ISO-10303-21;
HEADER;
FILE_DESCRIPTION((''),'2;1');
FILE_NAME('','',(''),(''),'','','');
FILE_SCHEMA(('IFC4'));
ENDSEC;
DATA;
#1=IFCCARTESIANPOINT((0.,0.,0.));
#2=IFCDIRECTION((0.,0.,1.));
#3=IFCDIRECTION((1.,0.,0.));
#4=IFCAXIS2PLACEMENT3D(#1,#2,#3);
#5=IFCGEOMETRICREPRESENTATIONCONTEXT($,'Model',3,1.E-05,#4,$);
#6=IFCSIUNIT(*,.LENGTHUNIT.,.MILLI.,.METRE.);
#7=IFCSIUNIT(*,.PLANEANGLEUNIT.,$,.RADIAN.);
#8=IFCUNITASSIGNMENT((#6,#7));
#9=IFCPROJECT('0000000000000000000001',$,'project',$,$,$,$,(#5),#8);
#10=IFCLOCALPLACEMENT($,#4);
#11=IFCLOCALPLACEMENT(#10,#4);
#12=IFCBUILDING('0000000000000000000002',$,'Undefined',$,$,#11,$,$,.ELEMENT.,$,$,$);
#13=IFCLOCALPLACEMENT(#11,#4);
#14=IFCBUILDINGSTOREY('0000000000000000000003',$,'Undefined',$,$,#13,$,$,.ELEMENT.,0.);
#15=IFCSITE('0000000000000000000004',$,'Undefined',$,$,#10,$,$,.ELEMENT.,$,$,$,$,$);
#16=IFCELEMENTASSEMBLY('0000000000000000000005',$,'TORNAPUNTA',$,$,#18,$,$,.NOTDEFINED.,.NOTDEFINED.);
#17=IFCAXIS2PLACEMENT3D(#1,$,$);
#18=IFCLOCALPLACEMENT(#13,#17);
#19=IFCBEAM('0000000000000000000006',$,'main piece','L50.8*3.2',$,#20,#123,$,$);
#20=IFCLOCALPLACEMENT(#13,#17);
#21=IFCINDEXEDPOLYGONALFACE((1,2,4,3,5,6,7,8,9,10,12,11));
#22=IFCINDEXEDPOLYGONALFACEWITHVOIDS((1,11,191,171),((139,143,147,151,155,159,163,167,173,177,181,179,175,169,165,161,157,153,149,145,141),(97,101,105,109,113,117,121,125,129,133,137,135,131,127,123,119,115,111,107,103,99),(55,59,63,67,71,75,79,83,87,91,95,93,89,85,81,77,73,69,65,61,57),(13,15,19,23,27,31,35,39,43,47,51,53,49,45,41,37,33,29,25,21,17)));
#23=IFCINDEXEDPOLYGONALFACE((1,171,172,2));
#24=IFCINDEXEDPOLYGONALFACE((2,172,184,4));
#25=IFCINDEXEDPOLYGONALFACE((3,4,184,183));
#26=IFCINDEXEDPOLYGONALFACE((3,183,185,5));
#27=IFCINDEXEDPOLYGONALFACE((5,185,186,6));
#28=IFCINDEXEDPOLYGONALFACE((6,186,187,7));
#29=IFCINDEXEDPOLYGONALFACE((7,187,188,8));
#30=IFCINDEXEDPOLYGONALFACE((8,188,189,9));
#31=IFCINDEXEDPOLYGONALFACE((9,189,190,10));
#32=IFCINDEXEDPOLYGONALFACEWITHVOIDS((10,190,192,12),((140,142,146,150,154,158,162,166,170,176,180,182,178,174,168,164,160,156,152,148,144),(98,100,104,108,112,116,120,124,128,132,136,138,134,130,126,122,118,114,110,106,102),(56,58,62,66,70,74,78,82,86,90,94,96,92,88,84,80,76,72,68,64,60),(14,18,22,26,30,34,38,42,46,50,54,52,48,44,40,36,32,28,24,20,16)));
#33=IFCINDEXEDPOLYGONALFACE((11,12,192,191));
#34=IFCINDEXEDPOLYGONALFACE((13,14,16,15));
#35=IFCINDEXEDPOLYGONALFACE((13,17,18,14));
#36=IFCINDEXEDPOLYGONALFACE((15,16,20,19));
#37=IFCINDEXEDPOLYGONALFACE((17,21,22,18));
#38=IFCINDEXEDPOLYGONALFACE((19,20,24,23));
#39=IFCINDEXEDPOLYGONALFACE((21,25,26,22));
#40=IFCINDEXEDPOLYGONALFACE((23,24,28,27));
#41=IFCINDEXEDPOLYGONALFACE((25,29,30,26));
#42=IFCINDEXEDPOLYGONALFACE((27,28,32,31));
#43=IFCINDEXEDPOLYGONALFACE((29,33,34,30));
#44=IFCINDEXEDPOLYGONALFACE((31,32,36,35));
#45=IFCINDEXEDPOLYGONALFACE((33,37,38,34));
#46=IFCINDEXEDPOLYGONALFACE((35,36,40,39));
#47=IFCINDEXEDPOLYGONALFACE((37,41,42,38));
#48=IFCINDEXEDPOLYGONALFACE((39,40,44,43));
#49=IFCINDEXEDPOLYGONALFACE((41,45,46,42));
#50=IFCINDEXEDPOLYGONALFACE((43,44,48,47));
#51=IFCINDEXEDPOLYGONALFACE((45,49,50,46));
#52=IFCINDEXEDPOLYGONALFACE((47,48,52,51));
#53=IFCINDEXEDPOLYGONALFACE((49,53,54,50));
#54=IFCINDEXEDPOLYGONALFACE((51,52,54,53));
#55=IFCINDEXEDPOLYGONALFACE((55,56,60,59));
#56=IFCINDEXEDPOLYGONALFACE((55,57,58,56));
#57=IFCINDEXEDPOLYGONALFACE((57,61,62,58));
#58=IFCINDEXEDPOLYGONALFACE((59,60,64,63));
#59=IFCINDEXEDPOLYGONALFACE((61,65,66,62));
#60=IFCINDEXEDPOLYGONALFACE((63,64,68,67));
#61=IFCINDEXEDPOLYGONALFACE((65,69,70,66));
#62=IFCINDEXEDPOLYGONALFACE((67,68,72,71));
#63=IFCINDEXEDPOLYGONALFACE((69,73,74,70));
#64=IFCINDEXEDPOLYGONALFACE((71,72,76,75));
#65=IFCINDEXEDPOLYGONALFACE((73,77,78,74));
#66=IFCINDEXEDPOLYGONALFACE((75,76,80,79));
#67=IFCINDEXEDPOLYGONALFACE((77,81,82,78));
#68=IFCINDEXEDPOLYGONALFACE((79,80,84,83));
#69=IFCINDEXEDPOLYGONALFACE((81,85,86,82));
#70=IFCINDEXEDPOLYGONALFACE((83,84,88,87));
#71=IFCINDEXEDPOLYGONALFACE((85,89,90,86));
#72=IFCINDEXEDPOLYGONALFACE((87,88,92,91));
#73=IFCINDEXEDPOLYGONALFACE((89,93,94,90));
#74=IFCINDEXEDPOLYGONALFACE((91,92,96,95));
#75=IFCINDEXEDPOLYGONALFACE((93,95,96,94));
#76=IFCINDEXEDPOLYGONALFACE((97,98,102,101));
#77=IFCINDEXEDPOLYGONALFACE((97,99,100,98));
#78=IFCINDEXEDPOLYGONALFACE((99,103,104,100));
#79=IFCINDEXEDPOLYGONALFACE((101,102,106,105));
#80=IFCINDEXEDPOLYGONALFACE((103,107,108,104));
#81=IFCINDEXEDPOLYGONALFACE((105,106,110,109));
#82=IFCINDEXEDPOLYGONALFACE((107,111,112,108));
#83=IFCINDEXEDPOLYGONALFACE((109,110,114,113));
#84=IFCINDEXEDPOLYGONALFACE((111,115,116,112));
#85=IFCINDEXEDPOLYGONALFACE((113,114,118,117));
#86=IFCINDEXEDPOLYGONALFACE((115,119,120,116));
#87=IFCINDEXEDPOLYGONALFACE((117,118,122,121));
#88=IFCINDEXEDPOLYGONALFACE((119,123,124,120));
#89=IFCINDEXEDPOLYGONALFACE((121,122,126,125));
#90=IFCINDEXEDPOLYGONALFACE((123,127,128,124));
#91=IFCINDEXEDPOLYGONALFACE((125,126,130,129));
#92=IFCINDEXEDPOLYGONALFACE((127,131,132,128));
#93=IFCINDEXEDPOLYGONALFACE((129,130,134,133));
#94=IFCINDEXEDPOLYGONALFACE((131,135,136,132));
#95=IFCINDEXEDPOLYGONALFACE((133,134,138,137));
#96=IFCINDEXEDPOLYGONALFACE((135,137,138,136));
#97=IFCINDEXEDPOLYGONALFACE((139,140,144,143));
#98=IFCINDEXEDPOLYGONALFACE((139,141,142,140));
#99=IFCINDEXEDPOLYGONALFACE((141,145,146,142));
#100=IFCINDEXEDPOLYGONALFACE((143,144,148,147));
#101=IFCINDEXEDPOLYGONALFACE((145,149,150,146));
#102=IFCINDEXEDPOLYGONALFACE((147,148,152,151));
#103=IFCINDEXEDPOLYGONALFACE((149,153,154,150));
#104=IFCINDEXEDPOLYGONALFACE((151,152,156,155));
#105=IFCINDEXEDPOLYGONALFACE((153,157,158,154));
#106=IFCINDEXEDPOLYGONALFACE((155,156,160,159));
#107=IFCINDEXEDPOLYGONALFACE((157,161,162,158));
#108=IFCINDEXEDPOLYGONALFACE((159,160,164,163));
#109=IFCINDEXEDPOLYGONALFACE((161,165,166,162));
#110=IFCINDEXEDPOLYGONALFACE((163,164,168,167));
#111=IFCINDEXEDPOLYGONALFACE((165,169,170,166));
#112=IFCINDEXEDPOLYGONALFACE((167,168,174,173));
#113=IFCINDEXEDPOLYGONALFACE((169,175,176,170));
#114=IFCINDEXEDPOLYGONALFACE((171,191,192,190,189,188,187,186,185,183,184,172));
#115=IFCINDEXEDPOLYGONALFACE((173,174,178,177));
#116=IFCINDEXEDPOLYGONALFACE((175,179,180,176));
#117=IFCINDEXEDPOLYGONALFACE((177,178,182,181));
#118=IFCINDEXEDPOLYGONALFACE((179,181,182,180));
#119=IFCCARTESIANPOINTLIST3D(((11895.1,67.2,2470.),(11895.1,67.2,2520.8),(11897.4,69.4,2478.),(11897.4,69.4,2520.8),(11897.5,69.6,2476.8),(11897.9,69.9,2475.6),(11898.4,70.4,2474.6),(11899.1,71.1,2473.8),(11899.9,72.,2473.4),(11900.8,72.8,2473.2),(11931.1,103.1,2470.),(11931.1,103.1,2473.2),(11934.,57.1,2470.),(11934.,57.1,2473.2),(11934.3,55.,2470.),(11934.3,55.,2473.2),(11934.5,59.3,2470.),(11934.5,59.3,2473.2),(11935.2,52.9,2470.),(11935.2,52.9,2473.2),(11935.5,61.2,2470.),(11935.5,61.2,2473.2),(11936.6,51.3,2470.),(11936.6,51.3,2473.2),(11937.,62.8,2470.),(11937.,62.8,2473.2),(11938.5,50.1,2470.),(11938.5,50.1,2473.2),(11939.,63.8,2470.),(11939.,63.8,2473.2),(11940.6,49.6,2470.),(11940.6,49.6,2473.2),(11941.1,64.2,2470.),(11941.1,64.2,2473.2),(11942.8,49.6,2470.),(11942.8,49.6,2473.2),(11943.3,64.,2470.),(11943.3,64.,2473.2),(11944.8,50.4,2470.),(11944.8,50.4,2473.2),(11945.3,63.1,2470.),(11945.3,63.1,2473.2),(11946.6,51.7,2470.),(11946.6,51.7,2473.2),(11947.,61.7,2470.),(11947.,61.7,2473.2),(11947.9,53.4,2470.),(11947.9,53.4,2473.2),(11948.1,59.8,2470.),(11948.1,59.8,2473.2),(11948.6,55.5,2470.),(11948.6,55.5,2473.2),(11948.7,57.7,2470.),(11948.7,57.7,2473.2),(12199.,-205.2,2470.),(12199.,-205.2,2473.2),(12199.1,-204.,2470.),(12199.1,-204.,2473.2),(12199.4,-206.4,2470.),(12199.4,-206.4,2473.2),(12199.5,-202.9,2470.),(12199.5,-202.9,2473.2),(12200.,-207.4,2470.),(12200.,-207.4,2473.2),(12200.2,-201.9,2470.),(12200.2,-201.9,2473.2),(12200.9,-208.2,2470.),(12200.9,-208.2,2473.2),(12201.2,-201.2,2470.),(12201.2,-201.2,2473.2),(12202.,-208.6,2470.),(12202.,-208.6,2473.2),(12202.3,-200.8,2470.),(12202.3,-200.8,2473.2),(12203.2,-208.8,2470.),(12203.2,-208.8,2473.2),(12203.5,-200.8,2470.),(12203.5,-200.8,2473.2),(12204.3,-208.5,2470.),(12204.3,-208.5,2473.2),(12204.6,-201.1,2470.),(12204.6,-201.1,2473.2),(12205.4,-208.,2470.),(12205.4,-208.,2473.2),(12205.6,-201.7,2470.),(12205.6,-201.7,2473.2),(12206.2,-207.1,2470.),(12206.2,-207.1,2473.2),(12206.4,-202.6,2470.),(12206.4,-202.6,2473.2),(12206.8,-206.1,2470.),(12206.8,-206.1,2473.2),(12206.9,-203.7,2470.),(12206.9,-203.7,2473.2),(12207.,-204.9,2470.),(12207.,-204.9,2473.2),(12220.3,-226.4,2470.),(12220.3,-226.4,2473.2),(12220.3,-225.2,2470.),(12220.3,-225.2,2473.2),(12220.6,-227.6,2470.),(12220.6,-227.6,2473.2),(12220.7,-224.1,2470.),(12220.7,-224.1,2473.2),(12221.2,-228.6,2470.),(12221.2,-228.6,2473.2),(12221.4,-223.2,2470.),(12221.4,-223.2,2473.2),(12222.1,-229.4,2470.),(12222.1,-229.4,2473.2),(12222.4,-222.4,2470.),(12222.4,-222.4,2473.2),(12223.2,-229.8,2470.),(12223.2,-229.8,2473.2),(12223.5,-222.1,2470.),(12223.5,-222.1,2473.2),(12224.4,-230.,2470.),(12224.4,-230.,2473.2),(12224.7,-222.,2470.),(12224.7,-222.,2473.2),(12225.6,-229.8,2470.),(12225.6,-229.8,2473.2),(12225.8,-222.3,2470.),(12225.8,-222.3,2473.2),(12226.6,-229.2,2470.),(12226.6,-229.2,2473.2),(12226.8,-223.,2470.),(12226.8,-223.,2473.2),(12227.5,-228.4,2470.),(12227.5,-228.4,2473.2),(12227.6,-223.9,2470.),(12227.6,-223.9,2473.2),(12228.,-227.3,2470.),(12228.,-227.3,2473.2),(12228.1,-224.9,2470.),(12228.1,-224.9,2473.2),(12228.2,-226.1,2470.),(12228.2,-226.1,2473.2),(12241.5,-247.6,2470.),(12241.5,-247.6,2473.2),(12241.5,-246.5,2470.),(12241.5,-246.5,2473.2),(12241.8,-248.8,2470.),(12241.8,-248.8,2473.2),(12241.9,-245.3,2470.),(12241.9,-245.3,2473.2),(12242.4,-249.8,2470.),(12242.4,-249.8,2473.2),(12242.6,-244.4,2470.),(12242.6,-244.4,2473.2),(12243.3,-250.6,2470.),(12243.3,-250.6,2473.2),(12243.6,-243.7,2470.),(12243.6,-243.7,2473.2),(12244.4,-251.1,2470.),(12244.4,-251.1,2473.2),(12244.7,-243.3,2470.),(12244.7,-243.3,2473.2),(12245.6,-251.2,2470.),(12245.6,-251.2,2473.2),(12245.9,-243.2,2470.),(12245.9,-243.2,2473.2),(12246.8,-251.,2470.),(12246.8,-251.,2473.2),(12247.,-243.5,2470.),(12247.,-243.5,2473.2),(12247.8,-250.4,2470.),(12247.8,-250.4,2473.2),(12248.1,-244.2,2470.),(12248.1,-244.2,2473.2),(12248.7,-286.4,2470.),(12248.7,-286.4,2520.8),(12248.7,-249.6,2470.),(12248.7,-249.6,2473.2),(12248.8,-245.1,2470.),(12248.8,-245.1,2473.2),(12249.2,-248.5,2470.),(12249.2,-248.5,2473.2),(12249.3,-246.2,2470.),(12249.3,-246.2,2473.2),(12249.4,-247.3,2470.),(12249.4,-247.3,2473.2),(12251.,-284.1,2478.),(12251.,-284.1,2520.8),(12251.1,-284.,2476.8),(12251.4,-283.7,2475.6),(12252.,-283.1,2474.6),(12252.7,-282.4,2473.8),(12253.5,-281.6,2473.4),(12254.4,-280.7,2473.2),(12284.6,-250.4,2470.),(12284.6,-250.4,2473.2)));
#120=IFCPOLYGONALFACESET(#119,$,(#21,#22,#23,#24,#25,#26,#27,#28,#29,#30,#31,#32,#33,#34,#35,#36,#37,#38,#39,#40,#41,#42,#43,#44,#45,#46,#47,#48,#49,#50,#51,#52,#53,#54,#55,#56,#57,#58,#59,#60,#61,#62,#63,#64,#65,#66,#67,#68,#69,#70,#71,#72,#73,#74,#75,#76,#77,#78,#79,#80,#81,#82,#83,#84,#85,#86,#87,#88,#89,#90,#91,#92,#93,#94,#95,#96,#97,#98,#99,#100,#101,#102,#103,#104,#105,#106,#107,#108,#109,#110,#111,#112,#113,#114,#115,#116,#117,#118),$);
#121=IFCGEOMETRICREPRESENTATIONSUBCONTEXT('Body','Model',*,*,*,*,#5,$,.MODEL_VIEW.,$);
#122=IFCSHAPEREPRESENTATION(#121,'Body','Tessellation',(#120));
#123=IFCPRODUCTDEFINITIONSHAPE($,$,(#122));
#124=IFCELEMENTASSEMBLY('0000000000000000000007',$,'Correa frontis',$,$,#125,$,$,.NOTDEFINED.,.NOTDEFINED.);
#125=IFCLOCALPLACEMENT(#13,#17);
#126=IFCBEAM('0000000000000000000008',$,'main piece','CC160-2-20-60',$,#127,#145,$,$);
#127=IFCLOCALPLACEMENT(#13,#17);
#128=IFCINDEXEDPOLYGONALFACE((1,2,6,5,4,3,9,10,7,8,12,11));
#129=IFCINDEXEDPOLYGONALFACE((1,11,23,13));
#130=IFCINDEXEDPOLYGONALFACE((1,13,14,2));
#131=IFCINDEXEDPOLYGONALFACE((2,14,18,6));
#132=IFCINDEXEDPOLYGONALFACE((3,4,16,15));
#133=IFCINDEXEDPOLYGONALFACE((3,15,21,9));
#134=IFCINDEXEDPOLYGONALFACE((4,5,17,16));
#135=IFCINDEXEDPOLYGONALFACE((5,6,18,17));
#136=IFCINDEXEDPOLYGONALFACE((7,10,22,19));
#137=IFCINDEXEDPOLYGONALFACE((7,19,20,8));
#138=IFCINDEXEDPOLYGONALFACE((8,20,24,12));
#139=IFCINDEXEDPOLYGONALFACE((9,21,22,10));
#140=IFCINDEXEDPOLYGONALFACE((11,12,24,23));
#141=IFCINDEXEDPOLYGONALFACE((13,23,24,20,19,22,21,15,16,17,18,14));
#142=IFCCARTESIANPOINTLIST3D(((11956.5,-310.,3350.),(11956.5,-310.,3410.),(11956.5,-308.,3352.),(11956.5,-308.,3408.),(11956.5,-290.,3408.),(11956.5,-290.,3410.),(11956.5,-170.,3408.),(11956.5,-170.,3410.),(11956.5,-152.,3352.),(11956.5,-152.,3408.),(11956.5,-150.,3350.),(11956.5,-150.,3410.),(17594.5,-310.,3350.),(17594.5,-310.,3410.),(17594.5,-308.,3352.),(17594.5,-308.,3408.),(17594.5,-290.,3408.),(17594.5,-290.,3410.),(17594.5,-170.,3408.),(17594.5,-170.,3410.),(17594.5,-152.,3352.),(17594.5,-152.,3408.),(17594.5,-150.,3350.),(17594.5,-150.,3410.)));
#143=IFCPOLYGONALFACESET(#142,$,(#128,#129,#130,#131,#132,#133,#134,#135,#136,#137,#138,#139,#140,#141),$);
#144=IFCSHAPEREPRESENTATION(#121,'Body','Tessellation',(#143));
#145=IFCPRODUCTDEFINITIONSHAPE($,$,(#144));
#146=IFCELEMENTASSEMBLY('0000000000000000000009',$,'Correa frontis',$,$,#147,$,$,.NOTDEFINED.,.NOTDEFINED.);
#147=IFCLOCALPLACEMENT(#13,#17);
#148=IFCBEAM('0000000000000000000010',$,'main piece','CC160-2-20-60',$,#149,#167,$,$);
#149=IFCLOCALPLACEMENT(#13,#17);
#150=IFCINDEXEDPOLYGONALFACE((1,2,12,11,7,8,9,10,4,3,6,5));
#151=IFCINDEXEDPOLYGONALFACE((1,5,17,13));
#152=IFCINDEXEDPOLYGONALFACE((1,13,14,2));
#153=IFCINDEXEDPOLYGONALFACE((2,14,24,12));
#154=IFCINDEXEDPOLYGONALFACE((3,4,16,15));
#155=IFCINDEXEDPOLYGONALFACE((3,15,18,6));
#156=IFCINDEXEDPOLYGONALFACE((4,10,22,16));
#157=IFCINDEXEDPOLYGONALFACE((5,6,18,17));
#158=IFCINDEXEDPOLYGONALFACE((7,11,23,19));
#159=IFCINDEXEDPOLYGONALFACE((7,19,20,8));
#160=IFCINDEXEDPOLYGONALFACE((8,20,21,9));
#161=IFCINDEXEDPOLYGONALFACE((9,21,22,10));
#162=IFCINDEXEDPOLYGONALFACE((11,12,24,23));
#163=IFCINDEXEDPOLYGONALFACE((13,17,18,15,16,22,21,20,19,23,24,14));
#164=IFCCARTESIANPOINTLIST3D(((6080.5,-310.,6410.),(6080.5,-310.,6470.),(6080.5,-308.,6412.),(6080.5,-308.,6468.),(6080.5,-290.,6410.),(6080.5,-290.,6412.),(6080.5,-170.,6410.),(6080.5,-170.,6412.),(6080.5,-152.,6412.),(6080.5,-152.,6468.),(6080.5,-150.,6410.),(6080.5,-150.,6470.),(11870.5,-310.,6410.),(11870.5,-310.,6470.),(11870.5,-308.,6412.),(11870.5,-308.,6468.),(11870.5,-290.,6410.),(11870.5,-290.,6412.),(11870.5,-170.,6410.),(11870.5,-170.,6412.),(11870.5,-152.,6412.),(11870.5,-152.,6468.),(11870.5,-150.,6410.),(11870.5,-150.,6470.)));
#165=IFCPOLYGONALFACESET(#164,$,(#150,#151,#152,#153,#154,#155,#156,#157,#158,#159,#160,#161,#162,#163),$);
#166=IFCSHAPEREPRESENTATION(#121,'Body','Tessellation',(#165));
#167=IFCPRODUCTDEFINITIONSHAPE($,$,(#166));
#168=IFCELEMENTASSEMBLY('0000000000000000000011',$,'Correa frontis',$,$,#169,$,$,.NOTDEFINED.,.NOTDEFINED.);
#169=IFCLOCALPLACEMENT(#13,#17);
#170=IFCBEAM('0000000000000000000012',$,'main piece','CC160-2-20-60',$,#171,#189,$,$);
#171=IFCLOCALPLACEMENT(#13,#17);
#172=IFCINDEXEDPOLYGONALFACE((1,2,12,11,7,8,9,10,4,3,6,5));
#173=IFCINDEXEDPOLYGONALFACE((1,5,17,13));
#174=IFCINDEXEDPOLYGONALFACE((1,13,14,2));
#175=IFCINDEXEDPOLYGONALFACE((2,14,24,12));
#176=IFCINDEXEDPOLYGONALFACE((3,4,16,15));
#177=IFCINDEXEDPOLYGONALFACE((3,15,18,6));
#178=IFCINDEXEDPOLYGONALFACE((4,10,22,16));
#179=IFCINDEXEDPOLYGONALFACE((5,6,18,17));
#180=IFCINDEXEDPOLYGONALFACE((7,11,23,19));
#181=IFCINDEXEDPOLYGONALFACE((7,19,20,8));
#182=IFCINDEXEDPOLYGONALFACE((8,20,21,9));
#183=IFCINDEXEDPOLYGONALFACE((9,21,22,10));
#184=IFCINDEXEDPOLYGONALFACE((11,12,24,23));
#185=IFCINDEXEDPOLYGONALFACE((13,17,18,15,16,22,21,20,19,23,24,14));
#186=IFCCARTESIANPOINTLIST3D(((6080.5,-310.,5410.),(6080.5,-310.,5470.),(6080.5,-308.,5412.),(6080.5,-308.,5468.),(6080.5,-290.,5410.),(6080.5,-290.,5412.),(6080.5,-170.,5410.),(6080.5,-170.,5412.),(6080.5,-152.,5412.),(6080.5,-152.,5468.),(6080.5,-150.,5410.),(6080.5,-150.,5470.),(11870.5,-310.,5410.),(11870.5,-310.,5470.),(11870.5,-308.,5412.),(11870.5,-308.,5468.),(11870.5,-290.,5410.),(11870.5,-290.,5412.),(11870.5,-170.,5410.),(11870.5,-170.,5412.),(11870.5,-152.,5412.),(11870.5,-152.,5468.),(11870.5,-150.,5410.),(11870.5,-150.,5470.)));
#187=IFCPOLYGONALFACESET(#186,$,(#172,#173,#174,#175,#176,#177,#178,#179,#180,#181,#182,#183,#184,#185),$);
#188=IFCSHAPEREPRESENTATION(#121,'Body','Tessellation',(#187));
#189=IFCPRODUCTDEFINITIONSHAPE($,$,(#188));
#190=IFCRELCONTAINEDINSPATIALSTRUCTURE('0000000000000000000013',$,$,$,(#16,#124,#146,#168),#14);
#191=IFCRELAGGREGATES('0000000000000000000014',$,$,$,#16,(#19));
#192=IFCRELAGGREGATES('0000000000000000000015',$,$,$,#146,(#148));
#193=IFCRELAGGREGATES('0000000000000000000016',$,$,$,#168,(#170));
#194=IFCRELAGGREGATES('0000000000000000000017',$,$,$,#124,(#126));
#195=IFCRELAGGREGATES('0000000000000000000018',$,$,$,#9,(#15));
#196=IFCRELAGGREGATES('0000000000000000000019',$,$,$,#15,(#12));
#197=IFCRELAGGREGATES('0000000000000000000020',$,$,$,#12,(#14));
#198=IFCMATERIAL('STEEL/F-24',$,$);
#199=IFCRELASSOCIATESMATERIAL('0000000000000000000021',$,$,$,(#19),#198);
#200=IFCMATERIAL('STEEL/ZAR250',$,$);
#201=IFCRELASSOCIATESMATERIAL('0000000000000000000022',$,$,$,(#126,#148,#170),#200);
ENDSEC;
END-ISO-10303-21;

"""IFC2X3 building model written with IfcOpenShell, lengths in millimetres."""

from ifc_helpers import new_model, si_unit, frame, origin_with_axes, origin_2d_with_axis, place, context, subcontext, project, spatial, circle, l_section, c_section, extrude, source, transform, mapped, material, element, aggregate, save


model = new_model("IFC2X3")

# Units and contexts
model_context = context("Model", 3, precision=1e-05, world=origin_with_axes())
body_context = subcontext(model_context, "Body", "Model", "MODEL_VIEW")
ifc_project = project(units=[si_unit("LENGTHUNIT", "METRE", prefix="MILLI"), si_unit("PLANEANGLEUNIT", "RADIAN")], contexts=[model_context])

# Site, building, storey
site_placement = place(None, origin_with_axes())
site = spatial("IfcSite", under=ifc_project, at=site_placement, Name="Undefined", CompositionType="ELEMENT")
building_placement = place(site_placement, origin_with_axes())
building = spatial("IfcBuilding", under=site, at=building_placement, Name="Undefined", CompositionType="ELEMENT")
storey_placement = place(building_placement, origin_with_axes())
storey = spatial("IfcBuildingStorey", under=building, at=storey_placement, Name="Undefined", CompositionType="ELEMENT", Elevation=0.0)

# Shared definitions
ifc_material_1 = material(Name="STEEL/F-24")

# Shared definitions
ifc_material_2 = material(Name="STEEL/ZAR250")

# Element assembly, beam, openings
shared_shape_1 = source(origin_with_axes(), body_context, "Body", "SweptSolid", [
    extrude(circle(Radius=4.0, at=origin_2d_with_axis()), frame((0.0, -3.3, 0.0), z_axis=(0.0, 1.0, 0.0), x_axis=(1.0, 0.0, 0.0)), (0.0, 0.0, 1.0), 3.4),
])
shared_shape_2 = source(origin_with_axes(), body_context, "Body", "SweptSolid", [
    extrude(circle(Radius=7.3, at=origin_2d_with_axis()), frame((0.0, -3.3, 0.0), z_axis=(0.0, 1.0, 0.0), x_axis=(1.0, 0.0, 0.0)), (0.0, 0.0, 1.0), 3.4),
])
assembly_1_placement = place(storey_placement, origin_with_axes())
assembly_1 = element("IfcElementAssembly", 1, at=assembly_1_placement, inside=storey, Name="TORNAPUNTA", AssemblyPlace="NOTDEFINED", PredefinedType="NOTDEFINED")
beam_1_placement = place(assembly_1_placement, frame((12266.7, -268.4, 2495.4), z_axis=(0.0, 0.0, 1.0), x_axis=(-0.707107, 0.707107, 0.0)))
beam_1 = element("IfcBeam", 2, at=beam_1_placement, material=ifc_material_1, Name="main piece", Description="L50.8*3.2", context=body_context, shape_type="SweptSolid", body=[
    extrude(l_section(Depth=50.8, Width=50.8, Thickness=3.2, FilletRadius=4.8, at=origin_2d_with_axis()), frame((500.0, 0.0, 0.0), z_axis=(-1.0, 0.0, 0.0), x_axis=(0.0, -1.0, 0.0)), (0.0, 0.0, 1.0), 500.0),
])
opening_1_placement = place(assembly_1_placement, frame((12245.4, -247.2, 2470.0), z_axis=(-0.707107, -0.707107, 0.0), x_axis=(-0.707107, 0.707107, 0.0)))
element("IfcOpeningElement", 3, at=opening_1_placement, cuts=beam_1, ObjectType="Opening", context=body_context, shape_type="MappedRepresentation", body=[
    mapped(shared_shape_1, transform((0.0, 0.0, 0.0))),
    mapped(shared_shape_1, transform((30.0, 0.0, 0.0))),
    mapped(shared_shape_1, transform((60.0, 0.0, 0.0))),
])
opening_2_placement = place(assembly_1_placement, frame((11941.4, 56.9, 2470.0), z_axis=(0.707107, 0.707107, 0.0), x_axis=(0.707107, -0.707107, 0.0)))
element("IfcOpeningElement", 4, at=opening_2_placement, cuts=beam_1, ObjectType="Opening", context=body_context, shape_type="MappedRepresentation", body=[
    mapped(shared_shape_2, transform((0.0, 0.0, 0.0))),
])
aggregate(assembly_1, [beam_1])

# Element assemblies, beams
assembly_2_placement = place(storey_placement, origin_with_axes())
assembly_2 = element("IfcElementAssembly", 5, at=assembly_2_placement, inside=storey, Name="Correa frontis", AssemblyPlace="NOTDEFINED", PredefinedType="NOTDEFINED")
beam_2_placement = place(assembly_2_placement, frame((11956.5, -230.0, 3380.0), z_axis=(0.0, 1.0, 0.0), x_axis=(1.0, 0.0, 0.0)))
beam_2 = element("IfcBeam", 6, at=beam_2_placement, material=ifc_material_2, Name="main piece", Description="CC160-2-20-60", context=body_context, shape_type="SweptSolid", body=[
    extrude(c_section(Depth=160.0, Width=60.0, WallThickness=2.0, Girth=20.0, at=origin_2d_with_axis()), frame((5638.0, 0.0, 0.0), z_axis=(-1.0, 0.0, 0.0), x_axis=(0.0, -1.0, 0.0)), (0.0, 0.0, 1.0), 5638.0),
])
assembly_3_placement = place(storey_placement, origin_with_axes())
assembly_3 = element("IfcElementAssembly", 7, at=assembly_3_placement, inside=storey, Name="Correa frontis", AssemblyPlace="NOTDEFINED", PredefinedType="NOTDEFINED")
beam_3_placement = place(assembly_3_placement, frame((11870.5, -230.0, 6440.0), z_axis=(0.0, 1.0, 0.0), x_axis=(-1.0, 0.0, 0.0)))
beam_3 = element("IfcBeam", 8, at=beam_3_placement, material=ifc_material_2, Name="main piece", Description="CC160-2-20-60", context=body_context, shape_type="SweptSolid", body=[
    extrude(c_section(Depth=160.0, Width=60.0, WallThickness=2.0, Girth=20.0, at=origin_2d_with_axis()), frame((5790.0, 0.0, 0.0), z_axis=(-1.0, 0.0, 0.0), x_axis=(0.0, -1.0, 0.0)), (0.0, 0.0, 1.0), 5790.0),
])
aggregate(assembly_3, [beam_3])
assembly_4_placement = place(storey_placement, origin_with_axes())
assembly_4 = element("IfcElementAssembly", 9, at=assembly_4_placement, inside=storey, Name="Correa frontis", AssemblyPlace="NOTDEFINED", PredefinedType="NOTDEFINED")
beam_4_placement = place(assembly_4_placement, frame((11870.5, -230.0, 5440.0), z_axis=(0.0, 1.0, 0.0), x_axis=(-1.0, 0.0, 0.0)))
beam_4 = element("IfcBeam", 10, at=beam_4_placement, material=ifc_material_2, Name="main piece", Description="CC160-2-20-60", context=body_context, shape_type="SweptSolid", body=[
    extrude(c_section(Depth=160.0, Width=60.0, WallThickness=2.0, Girth=20.0, at=origin_2d_with_axis()), frame((5790.0, 0.0, 0.0), z_axis=(-1.0, 0.0, 0.0), x_axis=(0.0, -1.0, 0.0)), (0.0, 0.0, 1.0), 5790.0),
])
aggregate(assembly_4, [beam_4])

aggregate(assembly_2, [beam_2])

save(model, "model.ifc")
